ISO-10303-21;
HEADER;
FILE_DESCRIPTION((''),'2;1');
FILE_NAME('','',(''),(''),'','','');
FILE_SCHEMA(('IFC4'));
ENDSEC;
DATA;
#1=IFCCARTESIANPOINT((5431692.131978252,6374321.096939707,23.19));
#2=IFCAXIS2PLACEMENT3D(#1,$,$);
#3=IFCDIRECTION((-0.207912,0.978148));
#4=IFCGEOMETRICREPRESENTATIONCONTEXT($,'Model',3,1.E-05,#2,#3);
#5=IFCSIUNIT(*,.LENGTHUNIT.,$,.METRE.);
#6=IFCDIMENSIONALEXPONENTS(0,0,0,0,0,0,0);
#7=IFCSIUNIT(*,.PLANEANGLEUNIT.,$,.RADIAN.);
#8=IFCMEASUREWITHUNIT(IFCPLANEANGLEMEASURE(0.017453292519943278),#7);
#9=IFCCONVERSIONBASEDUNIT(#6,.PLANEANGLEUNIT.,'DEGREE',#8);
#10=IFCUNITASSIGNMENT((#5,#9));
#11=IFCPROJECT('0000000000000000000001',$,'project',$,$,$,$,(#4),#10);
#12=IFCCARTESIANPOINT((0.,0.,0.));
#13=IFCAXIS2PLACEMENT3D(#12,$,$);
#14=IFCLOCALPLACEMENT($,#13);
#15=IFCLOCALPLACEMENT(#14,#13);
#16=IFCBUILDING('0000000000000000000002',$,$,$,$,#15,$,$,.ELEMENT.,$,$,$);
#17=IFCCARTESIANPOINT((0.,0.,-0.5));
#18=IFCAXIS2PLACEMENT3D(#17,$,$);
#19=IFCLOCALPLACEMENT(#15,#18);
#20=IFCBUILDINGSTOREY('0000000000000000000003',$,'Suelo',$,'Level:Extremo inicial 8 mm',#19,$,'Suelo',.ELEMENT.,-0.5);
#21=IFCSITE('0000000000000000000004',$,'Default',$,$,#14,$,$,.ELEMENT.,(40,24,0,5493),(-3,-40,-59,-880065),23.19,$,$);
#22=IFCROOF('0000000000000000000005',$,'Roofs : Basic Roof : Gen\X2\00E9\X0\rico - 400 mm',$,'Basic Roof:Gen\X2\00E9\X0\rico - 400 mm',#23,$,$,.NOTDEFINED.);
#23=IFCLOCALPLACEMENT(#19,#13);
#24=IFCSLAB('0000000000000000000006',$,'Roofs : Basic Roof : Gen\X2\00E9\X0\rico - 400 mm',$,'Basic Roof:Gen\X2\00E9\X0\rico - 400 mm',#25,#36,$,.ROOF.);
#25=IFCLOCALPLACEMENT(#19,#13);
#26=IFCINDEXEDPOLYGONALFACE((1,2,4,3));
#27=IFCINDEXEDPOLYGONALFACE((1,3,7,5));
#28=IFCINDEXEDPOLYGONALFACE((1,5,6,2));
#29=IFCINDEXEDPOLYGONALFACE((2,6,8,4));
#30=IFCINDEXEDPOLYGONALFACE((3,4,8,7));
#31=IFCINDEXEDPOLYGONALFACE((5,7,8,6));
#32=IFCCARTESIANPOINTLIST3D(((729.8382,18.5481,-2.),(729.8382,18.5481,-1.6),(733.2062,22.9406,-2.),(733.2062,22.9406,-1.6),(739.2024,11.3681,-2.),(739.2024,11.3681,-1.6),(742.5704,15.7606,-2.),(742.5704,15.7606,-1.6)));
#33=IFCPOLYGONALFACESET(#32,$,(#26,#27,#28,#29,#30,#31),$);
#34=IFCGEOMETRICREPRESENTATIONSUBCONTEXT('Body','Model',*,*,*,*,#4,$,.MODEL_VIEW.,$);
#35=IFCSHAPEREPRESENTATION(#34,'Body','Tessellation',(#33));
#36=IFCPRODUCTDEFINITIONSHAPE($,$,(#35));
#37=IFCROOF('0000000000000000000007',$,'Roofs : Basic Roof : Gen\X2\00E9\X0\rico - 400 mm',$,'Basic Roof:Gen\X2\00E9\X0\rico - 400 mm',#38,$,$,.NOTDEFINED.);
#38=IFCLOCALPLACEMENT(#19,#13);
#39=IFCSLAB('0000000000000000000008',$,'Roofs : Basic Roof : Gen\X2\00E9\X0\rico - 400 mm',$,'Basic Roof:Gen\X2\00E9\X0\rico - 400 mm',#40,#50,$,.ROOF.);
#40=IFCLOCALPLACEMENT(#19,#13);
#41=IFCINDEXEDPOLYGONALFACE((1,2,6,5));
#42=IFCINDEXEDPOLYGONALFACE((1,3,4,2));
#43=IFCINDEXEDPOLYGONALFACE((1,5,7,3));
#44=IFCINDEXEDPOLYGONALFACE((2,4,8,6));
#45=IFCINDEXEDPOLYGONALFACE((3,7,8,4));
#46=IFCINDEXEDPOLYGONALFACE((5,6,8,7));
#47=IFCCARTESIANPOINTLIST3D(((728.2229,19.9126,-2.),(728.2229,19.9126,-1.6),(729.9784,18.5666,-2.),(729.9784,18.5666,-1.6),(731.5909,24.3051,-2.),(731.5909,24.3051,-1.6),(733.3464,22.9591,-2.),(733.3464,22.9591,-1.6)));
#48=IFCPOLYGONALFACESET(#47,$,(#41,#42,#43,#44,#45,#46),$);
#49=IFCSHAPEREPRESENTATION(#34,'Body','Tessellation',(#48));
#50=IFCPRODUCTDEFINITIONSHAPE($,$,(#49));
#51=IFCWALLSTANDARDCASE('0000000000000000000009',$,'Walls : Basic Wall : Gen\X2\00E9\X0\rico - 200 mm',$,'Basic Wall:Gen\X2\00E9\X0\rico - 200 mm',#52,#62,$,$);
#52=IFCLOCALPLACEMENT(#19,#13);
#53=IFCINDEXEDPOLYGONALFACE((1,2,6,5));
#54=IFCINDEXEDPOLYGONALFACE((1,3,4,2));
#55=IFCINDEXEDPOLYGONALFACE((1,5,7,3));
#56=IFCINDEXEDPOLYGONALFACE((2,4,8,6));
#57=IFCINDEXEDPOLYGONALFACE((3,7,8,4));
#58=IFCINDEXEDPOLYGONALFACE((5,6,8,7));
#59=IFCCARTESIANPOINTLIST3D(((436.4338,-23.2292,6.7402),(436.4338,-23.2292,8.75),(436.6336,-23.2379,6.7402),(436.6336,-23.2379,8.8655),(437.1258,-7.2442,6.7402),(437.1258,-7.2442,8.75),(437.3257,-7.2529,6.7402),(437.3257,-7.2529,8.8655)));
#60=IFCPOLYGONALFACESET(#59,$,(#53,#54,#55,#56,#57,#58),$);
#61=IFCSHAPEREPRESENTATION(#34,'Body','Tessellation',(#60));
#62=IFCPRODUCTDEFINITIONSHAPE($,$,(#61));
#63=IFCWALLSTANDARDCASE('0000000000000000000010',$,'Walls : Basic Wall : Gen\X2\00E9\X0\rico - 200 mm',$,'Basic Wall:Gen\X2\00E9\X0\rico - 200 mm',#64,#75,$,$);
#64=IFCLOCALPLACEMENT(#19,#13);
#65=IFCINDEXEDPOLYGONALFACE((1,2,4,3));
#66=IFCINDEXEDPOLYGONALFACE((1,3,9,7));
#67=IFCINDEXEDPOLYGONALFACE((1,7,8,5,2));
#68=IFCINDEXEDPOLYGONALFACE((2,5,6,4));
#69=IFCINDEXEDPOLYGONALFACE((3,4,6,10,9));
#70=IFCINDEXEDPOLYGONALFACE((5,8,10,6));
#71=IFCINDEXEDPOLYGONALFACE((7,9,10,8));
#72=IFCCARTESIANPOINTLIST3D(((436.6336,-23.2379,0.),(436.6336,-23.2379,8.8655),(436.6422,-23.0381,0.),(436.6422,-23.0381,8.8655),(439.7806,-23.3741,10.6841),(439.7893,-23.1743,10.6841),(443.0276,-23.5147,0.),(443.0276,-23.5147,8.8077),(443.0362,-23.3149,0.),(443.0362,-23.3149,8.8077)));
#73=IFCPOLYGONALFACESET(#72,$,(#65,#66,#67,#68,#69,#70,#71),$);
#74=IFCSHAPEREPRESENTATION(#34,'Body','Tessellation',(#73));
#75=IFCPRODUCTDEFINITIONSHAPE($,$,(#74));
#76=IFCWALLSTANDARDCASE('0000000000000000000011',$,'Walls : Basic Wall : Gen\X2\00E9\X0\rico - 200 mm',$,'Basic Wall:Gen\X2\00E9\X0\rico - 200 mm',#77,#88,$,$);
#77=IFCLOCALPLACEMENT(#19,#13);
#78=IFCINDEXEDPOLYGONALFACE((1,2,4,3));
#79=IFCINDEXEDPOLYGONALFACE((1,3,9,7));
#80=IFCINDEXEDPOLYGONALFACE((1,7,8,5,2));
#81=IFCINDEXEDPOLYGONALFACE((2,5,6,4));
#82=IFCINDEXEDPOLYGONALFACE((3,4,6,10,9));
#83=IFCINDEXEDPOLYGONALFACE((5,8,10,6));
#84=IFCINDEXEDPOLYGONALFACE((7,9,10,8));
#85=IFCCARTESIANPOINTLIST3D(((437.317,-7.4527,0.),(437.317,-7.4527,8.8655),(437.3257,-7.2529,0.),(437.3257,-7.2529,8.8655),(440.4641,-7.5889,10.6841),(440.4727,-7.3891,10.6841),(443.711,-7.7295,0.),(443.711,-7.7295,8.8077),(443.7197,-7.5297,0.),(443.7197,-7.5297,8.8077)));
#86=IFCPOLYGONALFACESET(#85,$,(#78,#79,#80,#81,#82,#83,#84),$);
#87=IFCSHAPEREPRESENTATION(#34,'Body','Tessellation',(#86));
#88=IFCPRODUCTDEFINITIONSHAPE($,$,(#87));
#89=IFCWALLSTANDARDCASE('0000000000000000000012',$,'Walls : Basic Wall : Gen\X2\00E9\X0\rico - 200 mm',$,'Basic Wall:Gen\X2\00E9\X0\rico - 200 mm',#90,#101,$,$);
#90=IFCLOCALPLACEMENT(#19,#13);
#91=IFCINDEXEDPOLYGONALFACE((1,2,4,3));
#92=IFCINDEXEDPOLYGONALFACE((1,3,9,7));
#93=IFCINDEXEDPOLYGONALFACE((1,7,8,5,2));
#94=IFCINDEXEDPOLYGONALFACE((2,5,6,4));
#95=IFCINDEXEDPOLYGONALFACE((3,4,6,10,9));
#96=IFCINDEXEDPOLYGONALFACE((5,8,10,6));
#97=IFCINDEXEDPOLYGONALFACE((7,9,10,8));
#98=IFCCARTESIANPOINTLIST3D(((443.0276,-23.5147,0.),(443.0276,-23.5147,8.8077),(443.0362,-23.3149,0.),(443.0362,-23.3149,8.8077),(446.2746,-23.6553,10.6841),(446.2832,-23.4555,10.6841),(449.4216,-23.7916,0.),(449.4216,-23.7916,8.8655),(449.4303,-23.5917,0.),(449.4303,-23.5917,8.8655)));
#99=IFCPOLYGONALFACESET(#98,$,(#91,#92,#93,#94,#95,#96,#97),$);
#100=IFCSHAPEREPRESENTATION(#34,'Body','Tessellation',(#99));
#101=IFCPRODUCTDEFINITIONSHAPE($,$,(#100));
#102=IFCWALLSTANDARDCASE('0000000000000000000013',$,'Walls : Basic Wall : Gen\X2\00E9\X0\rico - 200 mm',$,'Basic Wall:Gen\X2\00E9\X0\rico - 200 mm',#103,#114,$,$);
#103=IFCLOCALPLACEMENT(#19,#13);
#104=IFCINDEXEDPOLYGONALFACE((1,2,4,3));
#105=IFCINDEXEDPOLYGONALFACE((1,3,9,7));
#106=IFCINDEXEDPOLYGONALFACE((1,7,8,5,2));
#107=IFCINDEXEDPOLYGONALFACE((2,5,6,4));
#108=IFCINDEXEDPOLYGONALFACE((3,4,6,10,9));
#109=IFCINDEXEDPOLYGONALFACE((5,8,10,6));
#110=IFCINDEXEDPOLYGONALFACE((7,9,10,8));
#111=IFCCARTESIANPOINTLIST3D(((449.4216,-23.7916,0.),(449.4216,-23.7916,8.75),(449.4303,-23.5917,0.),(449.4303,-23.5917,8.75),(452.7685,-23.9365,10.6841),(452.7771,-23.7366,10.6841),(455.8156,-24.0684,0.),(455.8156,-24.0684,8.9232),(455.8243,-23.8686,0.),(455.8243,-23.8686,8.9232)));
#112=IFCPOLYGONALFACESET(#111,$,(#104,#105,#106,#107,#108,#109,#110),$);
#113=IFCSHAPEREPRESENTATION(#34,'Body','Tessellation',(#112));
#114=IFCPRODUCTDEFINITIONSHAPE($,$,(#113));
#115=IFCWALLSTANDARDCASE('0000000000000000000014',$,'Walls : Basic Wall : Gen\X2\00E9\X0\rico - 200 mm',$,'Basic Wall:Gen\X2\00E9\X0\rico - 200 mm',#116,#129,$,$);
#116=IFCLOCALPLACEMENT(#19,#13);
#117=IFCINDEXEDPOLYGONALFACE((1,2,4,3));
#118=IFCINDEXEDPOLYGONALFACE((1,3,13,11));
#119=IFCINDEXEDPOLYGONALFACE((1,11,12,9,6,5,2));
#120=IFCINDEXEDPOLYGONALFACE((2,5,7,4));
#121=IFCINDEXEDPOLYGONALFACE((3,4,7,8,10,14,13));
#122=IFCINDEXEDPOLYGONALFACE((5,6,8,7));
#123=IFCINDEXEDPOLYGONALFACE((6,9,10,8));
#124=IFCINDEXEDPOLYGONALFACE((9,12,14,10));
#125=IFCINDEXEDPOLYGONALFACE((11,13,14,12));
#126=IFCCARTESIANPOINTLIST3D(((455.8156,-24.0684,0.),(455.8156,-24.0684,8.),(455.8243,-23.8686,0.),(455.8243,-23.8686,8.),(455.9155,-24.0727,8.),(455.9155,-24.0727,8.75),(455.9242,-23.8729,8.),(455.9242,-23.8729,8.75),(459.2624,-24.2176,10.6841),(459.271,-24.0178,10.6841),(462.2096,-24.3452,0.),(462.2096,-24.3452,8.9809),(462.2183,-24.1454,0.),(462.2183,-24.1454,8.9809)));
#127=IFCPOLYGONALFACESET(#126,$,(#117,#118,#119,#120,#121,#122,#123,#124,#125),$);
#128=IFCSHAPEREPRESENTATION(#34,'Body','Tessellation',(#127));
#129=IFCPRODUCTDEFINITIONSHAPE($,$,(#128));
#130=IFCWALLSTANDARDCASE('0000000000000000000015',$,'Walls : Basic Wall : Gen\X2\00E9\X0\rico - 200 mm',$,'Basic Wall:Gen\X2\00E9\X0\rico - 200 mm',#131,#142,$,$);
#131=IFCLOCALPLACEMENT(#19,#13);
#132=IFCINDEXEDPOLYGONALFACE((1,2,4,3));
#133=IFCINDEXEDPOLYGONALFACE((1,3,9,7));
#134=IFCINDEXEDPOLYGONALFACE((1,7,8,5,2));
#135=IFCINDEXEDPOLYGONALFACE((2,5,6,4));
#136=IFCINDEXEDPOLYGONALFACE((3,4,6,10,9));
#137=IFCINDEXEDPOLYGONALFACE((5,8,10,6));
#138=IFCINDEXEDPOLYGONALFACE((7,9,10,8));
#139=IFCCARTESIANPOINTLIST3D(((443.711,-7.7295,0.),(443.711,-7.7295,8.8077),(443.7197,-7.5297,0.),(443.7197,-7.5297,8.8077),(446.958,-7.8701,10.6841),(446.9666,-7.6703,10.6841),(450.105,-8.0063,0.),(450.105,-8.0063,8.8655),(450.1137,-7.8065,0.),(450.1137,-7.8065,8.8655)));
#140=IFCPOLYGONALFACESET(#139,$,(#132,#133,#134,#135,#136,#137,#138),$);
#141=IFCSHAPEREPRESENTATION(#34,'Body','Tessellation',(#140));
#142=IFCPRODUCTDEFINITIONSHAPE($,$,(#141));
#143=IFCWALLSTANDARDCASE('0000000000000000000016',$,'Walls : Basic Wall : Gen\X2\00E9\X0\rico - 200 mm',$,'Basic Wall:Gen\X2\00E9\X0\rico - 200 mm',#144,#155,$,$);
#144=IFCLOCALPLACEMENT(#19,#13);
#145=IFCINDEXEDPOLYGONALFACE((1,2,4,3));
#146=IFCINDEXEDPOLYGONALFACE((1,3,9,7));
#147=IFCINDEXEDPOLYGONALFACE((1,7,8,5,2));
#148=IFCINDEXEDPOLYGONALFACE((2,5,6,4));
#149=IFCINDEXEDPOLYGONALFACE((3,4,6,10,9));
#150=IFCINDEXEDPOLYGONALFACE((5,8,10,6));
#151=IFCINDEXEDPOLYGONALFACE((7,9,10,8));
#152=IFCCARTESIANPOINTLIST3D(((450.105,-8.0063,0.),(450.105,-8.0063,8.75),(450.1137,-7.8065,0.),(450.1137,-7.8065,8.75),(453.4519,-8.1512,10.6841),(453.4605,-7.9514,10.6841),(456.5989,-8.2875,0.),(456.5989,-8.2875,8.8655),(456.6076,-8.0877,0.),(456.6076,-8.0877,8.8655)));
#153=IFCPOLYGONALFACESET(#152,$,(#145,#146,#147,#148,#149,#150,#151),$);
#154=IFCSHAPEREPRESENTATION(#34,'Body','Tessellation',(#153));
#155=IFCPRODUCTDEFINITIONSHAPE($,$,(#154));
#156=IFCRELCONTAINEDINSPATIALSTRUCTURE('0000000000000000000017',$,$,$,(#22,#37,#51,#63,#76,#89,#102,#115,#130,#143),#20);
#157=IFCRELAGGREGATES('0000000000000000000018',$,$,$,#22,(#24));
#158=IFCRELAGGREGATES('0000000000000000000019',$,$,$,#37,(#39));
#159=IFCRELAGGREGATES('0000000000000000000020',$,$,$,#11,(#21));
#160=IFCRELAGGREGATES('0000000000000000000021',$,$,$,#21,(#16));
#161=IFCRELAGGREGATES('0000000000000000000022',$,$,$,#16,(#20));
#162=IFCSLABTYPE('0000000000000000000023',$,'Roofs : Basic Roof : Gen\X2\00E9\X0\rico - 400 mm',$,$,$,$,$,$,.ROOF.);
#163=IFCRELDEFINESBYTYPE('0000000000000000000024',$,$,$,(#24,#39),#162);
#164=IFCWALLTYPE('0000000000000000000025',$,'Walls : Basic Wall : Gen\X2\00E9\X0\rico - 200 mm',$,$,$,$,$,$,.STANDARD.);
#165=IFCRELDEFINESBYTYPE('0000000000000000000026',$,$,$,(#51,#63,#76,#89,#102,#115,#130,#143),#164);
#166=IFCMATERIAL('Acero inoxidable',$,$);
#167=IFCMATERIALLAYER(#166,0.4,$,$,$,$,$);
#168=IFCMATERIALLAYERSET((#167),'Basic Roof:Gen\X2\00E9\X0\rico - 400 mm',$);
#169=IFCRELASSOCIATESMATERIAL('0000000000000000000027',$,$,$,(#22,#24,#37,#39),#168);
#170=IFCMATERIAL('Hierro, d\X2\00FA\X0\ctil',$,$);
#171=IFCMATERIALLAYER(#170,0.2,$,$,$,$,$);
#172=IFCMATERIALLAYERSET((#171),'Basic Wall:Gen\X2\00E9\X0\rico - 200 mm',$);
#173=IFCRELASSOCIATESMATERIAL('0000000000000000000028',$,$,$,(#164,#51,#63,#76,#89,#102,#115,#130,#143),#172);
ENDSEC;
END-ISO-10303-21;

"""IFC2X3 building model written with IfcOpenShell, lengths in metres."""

from ifc_helpers import new_model, entity, si_unit, converted_unit, direction, frame, frame_2d, origin, place, context, subcontext, project, spatial, polyline, rectangle, extrude, clip, bounded_halfspace, material, layer, layer_set, layer_usage, type_object, element, aggregate, save


model = new_model("IFC2X3")

# Units and contexts
model_context = context("Model", 3, precision=1e-05, world=frame((5431692.131978252, 6374321.096939707, 23.19)), true_north=direction((-0.207912, 0.978148)))
body_context = subcontext(model_context, "Body", "Model", "MODEL_VIEW")
ifc_project = project(units=[si_unit("LENGTHUNIT", "METRE"), converted_unit("PLANEANGLEUNIT", "DEGREE", entity("IfcPlaneAngleMeasure", 0.017453292519943278), si_unit("PLANEANGLEUNIT", "RADIAN"), dimensions=[0, 0, 0, 0, 0, 0, 0])], contexts=[model_context])

# Site, building, storey
site_placement = place(None, origin())
site = spatial("IfcSite", under=ifc_project, at=site_placement, Name="Default", CompositionType="ELEMENT", RefLatitude=(40, 24, 0, 5493), RefLongitude=(-3, -40, -59, -880065), RefElevation=23.19)
building_placement = place(site_placement, origin())
building = spatial("IfcBuilding", under=site, at=building_placement, CompositionType="ELEMENT")
storey_placement = place(building_placement, frame((0.0, 0.0, -0.5)))
storey = spatial("IfcBuildingStorey", under=building, at=storey_placement, Name="Suelo", ObjectType="Level:Extremo inicial 8 mm", LongName="Suelo", CompositionType="ELEMENT", Elevation=-0.5)

# Roofs, slabs
ifc_material_1 = material(Name="Acero inoxidable")
ifc_layer_1 = layer(ifc_material_1, 0.4)
ifc_layer_set_1 = layer_set([ifc_layer_1], Name="Basic Roof:Genérico - 400 mm")
roof_1_placement = place(storey_placement, frame((729.8382, 11.3681, -2.0)))
roof_1 = element("IfcRoof", 1, at=roof_1_placement, inside=storey, material=ifc_layer_set_1, Name="Roofs : Basic Roof : Genérico - 400 mm", ObjectType="Basic Roof:Genérico - 400 mm", ShapeType="NOTDEFINED")
slab_type_1 = type_object("IfcSlabType", Name="Roofs : Basic Roof : Genérico - 400 mm", PredefinedType="ROOF")
slab_1_placement = place(roof_1_placement, origin())
slab_1 = element("IfcSlab", 2, at=slab_1_placement, type_object=slab_type_1, material=ifc_layer_set_1, Name="Roofs : Basic Roof : Genérico - 400 mm", ObjectType="Basic Roof:Genérico - 400 mm", PredefinedType="ROOF", context=body_context, shape_type="SweptSolid", body=[
    extrude(rectangle(XDim=5.5351, YDim=11.8, at=frame_2d((0.0, 0.0), x_axis=(-0.608472, -0.793576))), frame((6.3661, 5.7862, 0.0)), (0.0, 0.0, 1.0), 0.4),
])
aggregate(roof_1, [slab_1])
roof_2_placement = place(storey_placement, frame((728.2229, 18.5666, -2.0)))
roof_2 = element("IfcRoof", 3, at=roof_2_placement, inside=storey, material=ifc_layer_set_1, Name="Roofs : Basic Roof : Genérico - 400 mm", ObjectType="Basic Roof:Genérico - 400 mm", ShapeType="NOTDEFINED")
slab_2_placement = place(roof_2_placement, origin())
slab_2 = element("IfcSlab", 4, at=slab_2_placement, type_object=slab_type_1, material=ifc_layer_set_1, Name="Roofs : Basic Roof : Genérico - 400 mm", ObjectType="Basic Roof:Genérico - 400 mm", PredefinedType="ROOF", context=body_context, shape_type="SweptSolid", body=[
    extrude(rectangle(XDim=5.5351, YDim=2.2122, at=frame_2d((0.0, 0.0), x_axis=(-0.608472, -0.793576))), frame((2.5617, 2.8693, 0.0)), (0.0, 0.0, 1.0), 0.4),
])
aggregate(roof_2, [slab_2])

# Walls
ifc_material_2 = material(Name="Hierro, dúctil")
ifc_layer_2 = layer(ifc_material_2, 0.2)
ifc_layer_set_2 = layer_set([ifc_layer_2], Name="Basic Wall:Genérico - 200 mm")
ifc_layer_usage_1 = layer_usage(ifc_layer_set_2, "AXIS2", "NEGATIVE", 0.1)
wall_type = type_object("IfcWallType", Name="Walls : Basic Wall : Genérico - 200 mm", PredefinedType="STANDARD", material=ifc_layer_set_2)
wall_1_placement = place(storey_placement, frame((437.2258, -7.2485, 6.7402), z_axis=(0.0, 0.0, 1.0), x_axis=(-0.043255, -0.999064, 0.0)))
element("IfcWallStandardCase", 5, at=wall_1_placement, inside=storey, type_object=wall_type, material=ifc_layer_usage_1, Name="Walls : Basic Wall : Genérico - 200 mm", ObjectType="Basic Wall:Genérico - 200 mm", context=body_context, shape_type="Clipping", body=[
    clip(extrude(rectangle(XDim=16.0, YDim=0.2, at=frame_2d((8.0, 0.0), x_axis=(-1.0, 0.0))), origin(), (0.0, 0.0, 1.0), 2.1253), bounded_halfspace(frame((0.0, -0.1, 2.0098), z_axis=(0.0, -0.5, 0.866025), x_axis=(1.0, 0.0, 0.0)), False, frame((0.0, -0.1, 2.0098)), polyline([(0.0, 0.0), (16.0, 0.0), (16.0, 0.2), (15.8, 0.2), (0.2, 0.2), (0.0, 0.2), (0.0, 0.0)]))),
])
ifc_layer_usage_2 = layer_usage(ifc_layer_set_2, "AXIS2", "NEGATIVE", 0.1)
wall_2_placement = place(storey_placement, frame((436.6379, -23.138, 0.0), z_axis=(0.0, 0.0, 1.0), x_axis=(0.999064, -0.043255, 0.0)))
element("IfcWallStandardCase", 6, at=wall_2_placement, inside=storey, type_object=wall_type, material=ifc_layer_usage_2, Name="Walls : Basic Wall : Genérico - 200 mm", ObjectType="Basic Wall:Genérico - 200 mm", context=body_context, shape_type="Clipping", body=[
    clip(clip(extrude(rectangle(XDim=6.4, YDim=0.2, at=frame_2d((3.2, 0.0), x_axis=(-1.0, 0.0))), origin(), (0.0, 0.0, 1.0), 10.6841), bounded_halfspace(frame((3.15, -0.1, 10.6841), z_axis=(0.5, 0.0, 0.866025), x_axis=(0.0, 1.0, 0.0)), False, frame((3.15, -0.1, 10.6841)), polyline([(0.0, 0.0), (3.25, 0.0), (3.25, 0.2), (0.0, 0.2), (0.0, 0.0)]))), bounded_halfspace(frame((0.0, -0.1, 8.8655), z_axis=(-0.5, 0.0, 0.866025), x_axis=(0.0, -1.0, 0.0)), False, frame((0.0, -0.1, 8.8655)), polyline([(0.0, 0.0), (3.15, 0.0), (3.15, 0.2), (0.0, 0.2), (0.0, 0.0)]))),
])
ifc_layer_usage_3 = layer_usage(ifc_layer_set_2, "AXIS2", "NEGATIVE", 0.1)
wall_3_placement = place(storey_placement, frame((443.7153, -7.6296, 0.0), z_axis=(0.0, 0.0, 1.0), x_axis=(-0.999064, 0.043255, 0.0)))
element("IfcWallStandardCase", 7, at=wall_3_placement, inside=storey, type_object=wall_type, material=ifc_layer_usage_3, Name="Walls : Basic Wall : Genérico - 200 mm", ObjectType="Basic Wall:Genérico - 200 mm", context=body_context, shape_type="Clipping", body=[
    clip(clip(extrude(rectangle(XDim=6.4, YDim=0.2, at=frame_2d((3.2, 0.0), x_axis=(-1.0, 0.0))), origin(), (0.0, 0.0, 1.0), 10.6841), bounded_halfspace(frame((0.0, -0.1, 8.8077), z_axis=(-0.5, 0.0, 0.866025), x_axis=(0.0, -1.0, 0.0)), False, frame((0.0, -0.1, 8.8077)), polyline([(0.0, 0.0), (3.25, 0.0), (3.25, 0.2), (0.0, 0.2), (0.0, 0.0)]))), bounded_halfspace(frame((3.25, -0.1, 10.6841), z_axis=(0.5, 0.0, 0.866025), x_axis=(0.0, 1.0, 0.0)), False, frame((3.25, -0.1, 10.6841)), polyline([(0.0, 0.0), (3.15, 0.0), (3.15, 0.2), (0.0, 0.2), (0.0, 0.0)]))),
])
ifc_layer_usage_4 = layer_usage(ifc_layer_set_2, "AXIS2", "NEGATIVE", 0.1)
wall_4_placement = place(storey_placement, frame((443.0319, -23.4148, 0.0), z_axis=(0.0, 0.0, 1.0), x_axis=(0.999064, -0.043255, 0.0)))
element("IfcWallStandardCase", 8, at=wall_4_placement, inside=storey, type_object=wall_type, material=ifc_layer_usage_4, Name="Walls : Basic Wall : Genérico - 200 mm", ObjectType="Basic Wall:Genérico - 200 mm", context=body_context, shape_type="Clipping", body=[
    clip(clip(extrude(rectangle(XDim=6.4, YDim=0.2, at=frame_2d((3.2, 0.0), x_axis=(-1.0, 0.0))), origin(), (0.0, 0.0, 1.0), 10.6841), bounded_halfspace(frame((3.25, -0.1, 10.6841), z_axis=(0.5, 0.0, 0.866025), x_axis=(0.0, 1.0, 0.0)), False, frame((3.25, -0.1, 10.6841)), polyline([(0.0, 0.0), (3.15, 0.0), (3.15, 0.2), (0.0, 0.2), (0.0, 0.0)]))), bounded_halfspace(frame((0.0, -0.1, 8.8077), z_axis=(-0.5, 0.0, 0.866025), x_axis=(0.0, -1.0, 0.0)), False, frame((0.0, -0.1, 8.8077)), polyline([(0.0, 0.0), (3.25, 0.0), (3.25, 0.2), (0.0, 0.2), (0.0, 0.0)]))),
])
ifc_layer_usage_5 = layer_usage(ifc_layer_set_2, "AXIS2", "NEGATIVE", 0.1)
wall_5_placement = place(storey_placement, frame((449.4259, -23.6916, 0.0), z_axis=(0.0, 0.0, 1.0), x_axis=(0.999064, -0.043255, 0.0)))
element("IfcWallStandardCase", 9, at=wall_5_placement, inside=storey, type_object=wall_type, material=ifc_layer_usage_5, Name="Walls : Basic Wall : Genérico - 200 mm", ObjectType="Basic Wall:Genérico - 200 mm", context=body_context, shape_type="Clipping", body=[
    clip(clip(extrude(rectangle(XDim=6.4, YDim=0.2, at=frame_2d((3.2, 0.0), x_axis=(-1.0, 0.0))), origin(), (0.0, 0.0, 1.0), 10.6841), bounded_halfspace(frame((3.35, -0.1, 10.6841), z_axis=(0.5, 0.0, 0.866025), x_axis=(0.0, 1.0, 0.0)), False, frame((3.35, -0.1, 10.6841)), polyline([(0.0, 0.0), (3.05, 0.0), (3.05, 0.2), (0.0, 0.2), (0.0, 0.0)]))), bounded_halfspace(frame((0.0, -0.1, 8.75), z_axis=(-0.5, 0.0, 0.866025), x_axis=(0.0, -1.0, 0.0)), False, frame((0.0, -0.1, 8.75)), polyline([(0.0, 0.0), (3.35, 0.0), (3.35, 0.2), (0.0, 0.2), (0.0, 0.0)]))),
])
ifc_layer_usage_6 = layer_usage(ifc_layer_set_2, "AXIS2", "NEGATIVE", 0.1)
wall_6_placement = place(storey_placement, frame((455.8199, -23.9685, 0.0), z_axis=(0.0, 0.0, 1.0), x_axis=(0.999064, -0.043255, 0.0)))
element("IfcWallStandardCase", 10, at=wall_6_placement, inside=storey, type_object=wall_type, material=ifc_layer_usage_6, Name="Walls : Basic Wall : Genérico - 200 mm", ObjectType="Basic Wall:Genérico - 200 mm", context=body_context, shape_type="Clipping", body=[
    clip(clip(clip(extrude(rectangle(XDim=6.4, YDim=0.2, at=frame_2d((3.2, 0.0), x_axis=(-1.0, 0.0))), origin(), (0.0, 0.0, 1.0), 10.6841), bounded_halfspace(frame((3.45, -0.1, 10.6841), z_axis=(0.5, 0.0, 0.866025), x_axis=(0.0, 1.0, 0.0)), False, frame((3.45, -0.1, 10.6841)), polyline([(0.0, 0.0), (2.95, 0.0), (2.95, 0.2), (0.0, 0.2), (0.0, 0.0)]))), bounded_halfspace(frame((0.1, -0.1, 8.75), z_axis=(-0.5, 0.0, 0.866025), x_axis=(0.0, -1.0, 0.0)), False, frame((0.1, -0.1, 8.75)), polyline([(0.0, 0.0), (3.35, 0.0), (3.35, 0.2), (0.0, 0.2), (0.0, 0.0)]))), bounded_halfspace(frame((0.0, -0.1, 8.0), z_axis=(0.0, 0.0, 1.0), x_axis=(0.0, 1.0, 0.0)), False, frame((0.0, -0.1, 8.0)), polyline([(0.0, 0.0), (0.1, 0.0), (0.1, 0.2), (0.0, 0.2), (0.0, 0.0)]))),
])
ifc_layer_usage_7 = layer_usage(ifc_layer_set_2, "AXIS2", "NEGATIVE", 0.1)
wall_7_placement = place(storey_placement, frame((450.1094, -7.9064, 0.0), z_axis=(0.0, 0.0, 1.0), x_axis=(-0.999064, 0.043255, 0.0)))
element("IfcWallStandardCase", 11, at=wall_7_placement, inside=storey, type_object=wall_type, material=ifc_layer_usage_7, Name="Walls : Basic Wall : Genérico - 200 mm", ObjectType="Basic Wall:Genérico - 200 mm", context=body_context, shape_type="Clipping", body=[
    clip(clip(extrude(rectangle(XDim=6.4, YDim=0.2, at=frame_2d((3.2, 0.0), x_axis=(-1.0, 0.0))), origin(), (0.0, 0.0, 1.0), 10.6841), bounded_halfspace(frame((0.0, -0.1, 8.8655), z_axis=(-0.5, 0.0, 0.866025), x_axis=(0.0, -1.0, 0.0)), False, frame((0.0, -0.1, 8.8655)), polyline([(0.0, 0.0), (3.15, 0.0), (3.15, 0.2), (0.0, 0.2), (0.0, 0.0)]))), bounded_halfspace(frame((3.15, -0.1, 10.6841), z_axis=(0.5, 0.0, 0.866025), x_axis=(0.0, 1.0, 0.0)), False, frame((3.15, -0.1, 10.6841)), polyline([(0.0, 0.0), (3.25, 0.0), (3.25, 0.2), (0.0, 0.2), (0.0, 0.0)]))),
])
ifc_layer_usage_8 = layer_usage(ifc_layer_set_2, "AXIS2", "NEGATIVE", 0.1)
wall_8_placement = place(storey_placement, frame((456.6033, -8.1876, 0.0), z_axis=(0.0, 0.0, 1.0), x_axis=(-0.999064, 0.043255, 0.0)))
element("IfcWallStandardCase", 12, at=wall_8_placement, inside=storey, type_object=wall_type, material=ifc_layer_usage_8, Name="Walls : Basic Wall : Genérico - 200 mm", ObjectType="Basic Wall:Genérico - 200 mm", context=body_context, shape_type="Clipping", body=[
    clip(clip(extrude(rectangle(XDim=6.5, YDim=0.2, at=frame_2d((3.25, 0.0), x_axis=(-1.0, 0.0))), origin(), (0.0, 0.0, 1.0), 10.6841), bounded_halfspace(frame((0.0, -0.1, 8.8655), z_axis=(-0.5, 0.0, 0.866025), x_axis=(0.0, -1.0, 0.0)), False, frame((0.0, -0.1, 8.8655)), polyline([(0.0, 0.0), (3.15, 0.0), (3.15, 0.2), (0.0, 0.2), (0.0, 0.0)]))), bounded_halfspace(frame((3.15, -0.1, 10.6841), z_axis=(0.5, 0.0, 0.866025), x_axis=(0.0, 1.0, 0.0)), False, frame((3.15, -0.1, 10.6841)), polyline([(0.0, 0.0), (3.35, 0.0), (3.35, 0.2), (0.0, 0.2), (0.0, 0.0)]))),
])

save(model, "model.ifc")
